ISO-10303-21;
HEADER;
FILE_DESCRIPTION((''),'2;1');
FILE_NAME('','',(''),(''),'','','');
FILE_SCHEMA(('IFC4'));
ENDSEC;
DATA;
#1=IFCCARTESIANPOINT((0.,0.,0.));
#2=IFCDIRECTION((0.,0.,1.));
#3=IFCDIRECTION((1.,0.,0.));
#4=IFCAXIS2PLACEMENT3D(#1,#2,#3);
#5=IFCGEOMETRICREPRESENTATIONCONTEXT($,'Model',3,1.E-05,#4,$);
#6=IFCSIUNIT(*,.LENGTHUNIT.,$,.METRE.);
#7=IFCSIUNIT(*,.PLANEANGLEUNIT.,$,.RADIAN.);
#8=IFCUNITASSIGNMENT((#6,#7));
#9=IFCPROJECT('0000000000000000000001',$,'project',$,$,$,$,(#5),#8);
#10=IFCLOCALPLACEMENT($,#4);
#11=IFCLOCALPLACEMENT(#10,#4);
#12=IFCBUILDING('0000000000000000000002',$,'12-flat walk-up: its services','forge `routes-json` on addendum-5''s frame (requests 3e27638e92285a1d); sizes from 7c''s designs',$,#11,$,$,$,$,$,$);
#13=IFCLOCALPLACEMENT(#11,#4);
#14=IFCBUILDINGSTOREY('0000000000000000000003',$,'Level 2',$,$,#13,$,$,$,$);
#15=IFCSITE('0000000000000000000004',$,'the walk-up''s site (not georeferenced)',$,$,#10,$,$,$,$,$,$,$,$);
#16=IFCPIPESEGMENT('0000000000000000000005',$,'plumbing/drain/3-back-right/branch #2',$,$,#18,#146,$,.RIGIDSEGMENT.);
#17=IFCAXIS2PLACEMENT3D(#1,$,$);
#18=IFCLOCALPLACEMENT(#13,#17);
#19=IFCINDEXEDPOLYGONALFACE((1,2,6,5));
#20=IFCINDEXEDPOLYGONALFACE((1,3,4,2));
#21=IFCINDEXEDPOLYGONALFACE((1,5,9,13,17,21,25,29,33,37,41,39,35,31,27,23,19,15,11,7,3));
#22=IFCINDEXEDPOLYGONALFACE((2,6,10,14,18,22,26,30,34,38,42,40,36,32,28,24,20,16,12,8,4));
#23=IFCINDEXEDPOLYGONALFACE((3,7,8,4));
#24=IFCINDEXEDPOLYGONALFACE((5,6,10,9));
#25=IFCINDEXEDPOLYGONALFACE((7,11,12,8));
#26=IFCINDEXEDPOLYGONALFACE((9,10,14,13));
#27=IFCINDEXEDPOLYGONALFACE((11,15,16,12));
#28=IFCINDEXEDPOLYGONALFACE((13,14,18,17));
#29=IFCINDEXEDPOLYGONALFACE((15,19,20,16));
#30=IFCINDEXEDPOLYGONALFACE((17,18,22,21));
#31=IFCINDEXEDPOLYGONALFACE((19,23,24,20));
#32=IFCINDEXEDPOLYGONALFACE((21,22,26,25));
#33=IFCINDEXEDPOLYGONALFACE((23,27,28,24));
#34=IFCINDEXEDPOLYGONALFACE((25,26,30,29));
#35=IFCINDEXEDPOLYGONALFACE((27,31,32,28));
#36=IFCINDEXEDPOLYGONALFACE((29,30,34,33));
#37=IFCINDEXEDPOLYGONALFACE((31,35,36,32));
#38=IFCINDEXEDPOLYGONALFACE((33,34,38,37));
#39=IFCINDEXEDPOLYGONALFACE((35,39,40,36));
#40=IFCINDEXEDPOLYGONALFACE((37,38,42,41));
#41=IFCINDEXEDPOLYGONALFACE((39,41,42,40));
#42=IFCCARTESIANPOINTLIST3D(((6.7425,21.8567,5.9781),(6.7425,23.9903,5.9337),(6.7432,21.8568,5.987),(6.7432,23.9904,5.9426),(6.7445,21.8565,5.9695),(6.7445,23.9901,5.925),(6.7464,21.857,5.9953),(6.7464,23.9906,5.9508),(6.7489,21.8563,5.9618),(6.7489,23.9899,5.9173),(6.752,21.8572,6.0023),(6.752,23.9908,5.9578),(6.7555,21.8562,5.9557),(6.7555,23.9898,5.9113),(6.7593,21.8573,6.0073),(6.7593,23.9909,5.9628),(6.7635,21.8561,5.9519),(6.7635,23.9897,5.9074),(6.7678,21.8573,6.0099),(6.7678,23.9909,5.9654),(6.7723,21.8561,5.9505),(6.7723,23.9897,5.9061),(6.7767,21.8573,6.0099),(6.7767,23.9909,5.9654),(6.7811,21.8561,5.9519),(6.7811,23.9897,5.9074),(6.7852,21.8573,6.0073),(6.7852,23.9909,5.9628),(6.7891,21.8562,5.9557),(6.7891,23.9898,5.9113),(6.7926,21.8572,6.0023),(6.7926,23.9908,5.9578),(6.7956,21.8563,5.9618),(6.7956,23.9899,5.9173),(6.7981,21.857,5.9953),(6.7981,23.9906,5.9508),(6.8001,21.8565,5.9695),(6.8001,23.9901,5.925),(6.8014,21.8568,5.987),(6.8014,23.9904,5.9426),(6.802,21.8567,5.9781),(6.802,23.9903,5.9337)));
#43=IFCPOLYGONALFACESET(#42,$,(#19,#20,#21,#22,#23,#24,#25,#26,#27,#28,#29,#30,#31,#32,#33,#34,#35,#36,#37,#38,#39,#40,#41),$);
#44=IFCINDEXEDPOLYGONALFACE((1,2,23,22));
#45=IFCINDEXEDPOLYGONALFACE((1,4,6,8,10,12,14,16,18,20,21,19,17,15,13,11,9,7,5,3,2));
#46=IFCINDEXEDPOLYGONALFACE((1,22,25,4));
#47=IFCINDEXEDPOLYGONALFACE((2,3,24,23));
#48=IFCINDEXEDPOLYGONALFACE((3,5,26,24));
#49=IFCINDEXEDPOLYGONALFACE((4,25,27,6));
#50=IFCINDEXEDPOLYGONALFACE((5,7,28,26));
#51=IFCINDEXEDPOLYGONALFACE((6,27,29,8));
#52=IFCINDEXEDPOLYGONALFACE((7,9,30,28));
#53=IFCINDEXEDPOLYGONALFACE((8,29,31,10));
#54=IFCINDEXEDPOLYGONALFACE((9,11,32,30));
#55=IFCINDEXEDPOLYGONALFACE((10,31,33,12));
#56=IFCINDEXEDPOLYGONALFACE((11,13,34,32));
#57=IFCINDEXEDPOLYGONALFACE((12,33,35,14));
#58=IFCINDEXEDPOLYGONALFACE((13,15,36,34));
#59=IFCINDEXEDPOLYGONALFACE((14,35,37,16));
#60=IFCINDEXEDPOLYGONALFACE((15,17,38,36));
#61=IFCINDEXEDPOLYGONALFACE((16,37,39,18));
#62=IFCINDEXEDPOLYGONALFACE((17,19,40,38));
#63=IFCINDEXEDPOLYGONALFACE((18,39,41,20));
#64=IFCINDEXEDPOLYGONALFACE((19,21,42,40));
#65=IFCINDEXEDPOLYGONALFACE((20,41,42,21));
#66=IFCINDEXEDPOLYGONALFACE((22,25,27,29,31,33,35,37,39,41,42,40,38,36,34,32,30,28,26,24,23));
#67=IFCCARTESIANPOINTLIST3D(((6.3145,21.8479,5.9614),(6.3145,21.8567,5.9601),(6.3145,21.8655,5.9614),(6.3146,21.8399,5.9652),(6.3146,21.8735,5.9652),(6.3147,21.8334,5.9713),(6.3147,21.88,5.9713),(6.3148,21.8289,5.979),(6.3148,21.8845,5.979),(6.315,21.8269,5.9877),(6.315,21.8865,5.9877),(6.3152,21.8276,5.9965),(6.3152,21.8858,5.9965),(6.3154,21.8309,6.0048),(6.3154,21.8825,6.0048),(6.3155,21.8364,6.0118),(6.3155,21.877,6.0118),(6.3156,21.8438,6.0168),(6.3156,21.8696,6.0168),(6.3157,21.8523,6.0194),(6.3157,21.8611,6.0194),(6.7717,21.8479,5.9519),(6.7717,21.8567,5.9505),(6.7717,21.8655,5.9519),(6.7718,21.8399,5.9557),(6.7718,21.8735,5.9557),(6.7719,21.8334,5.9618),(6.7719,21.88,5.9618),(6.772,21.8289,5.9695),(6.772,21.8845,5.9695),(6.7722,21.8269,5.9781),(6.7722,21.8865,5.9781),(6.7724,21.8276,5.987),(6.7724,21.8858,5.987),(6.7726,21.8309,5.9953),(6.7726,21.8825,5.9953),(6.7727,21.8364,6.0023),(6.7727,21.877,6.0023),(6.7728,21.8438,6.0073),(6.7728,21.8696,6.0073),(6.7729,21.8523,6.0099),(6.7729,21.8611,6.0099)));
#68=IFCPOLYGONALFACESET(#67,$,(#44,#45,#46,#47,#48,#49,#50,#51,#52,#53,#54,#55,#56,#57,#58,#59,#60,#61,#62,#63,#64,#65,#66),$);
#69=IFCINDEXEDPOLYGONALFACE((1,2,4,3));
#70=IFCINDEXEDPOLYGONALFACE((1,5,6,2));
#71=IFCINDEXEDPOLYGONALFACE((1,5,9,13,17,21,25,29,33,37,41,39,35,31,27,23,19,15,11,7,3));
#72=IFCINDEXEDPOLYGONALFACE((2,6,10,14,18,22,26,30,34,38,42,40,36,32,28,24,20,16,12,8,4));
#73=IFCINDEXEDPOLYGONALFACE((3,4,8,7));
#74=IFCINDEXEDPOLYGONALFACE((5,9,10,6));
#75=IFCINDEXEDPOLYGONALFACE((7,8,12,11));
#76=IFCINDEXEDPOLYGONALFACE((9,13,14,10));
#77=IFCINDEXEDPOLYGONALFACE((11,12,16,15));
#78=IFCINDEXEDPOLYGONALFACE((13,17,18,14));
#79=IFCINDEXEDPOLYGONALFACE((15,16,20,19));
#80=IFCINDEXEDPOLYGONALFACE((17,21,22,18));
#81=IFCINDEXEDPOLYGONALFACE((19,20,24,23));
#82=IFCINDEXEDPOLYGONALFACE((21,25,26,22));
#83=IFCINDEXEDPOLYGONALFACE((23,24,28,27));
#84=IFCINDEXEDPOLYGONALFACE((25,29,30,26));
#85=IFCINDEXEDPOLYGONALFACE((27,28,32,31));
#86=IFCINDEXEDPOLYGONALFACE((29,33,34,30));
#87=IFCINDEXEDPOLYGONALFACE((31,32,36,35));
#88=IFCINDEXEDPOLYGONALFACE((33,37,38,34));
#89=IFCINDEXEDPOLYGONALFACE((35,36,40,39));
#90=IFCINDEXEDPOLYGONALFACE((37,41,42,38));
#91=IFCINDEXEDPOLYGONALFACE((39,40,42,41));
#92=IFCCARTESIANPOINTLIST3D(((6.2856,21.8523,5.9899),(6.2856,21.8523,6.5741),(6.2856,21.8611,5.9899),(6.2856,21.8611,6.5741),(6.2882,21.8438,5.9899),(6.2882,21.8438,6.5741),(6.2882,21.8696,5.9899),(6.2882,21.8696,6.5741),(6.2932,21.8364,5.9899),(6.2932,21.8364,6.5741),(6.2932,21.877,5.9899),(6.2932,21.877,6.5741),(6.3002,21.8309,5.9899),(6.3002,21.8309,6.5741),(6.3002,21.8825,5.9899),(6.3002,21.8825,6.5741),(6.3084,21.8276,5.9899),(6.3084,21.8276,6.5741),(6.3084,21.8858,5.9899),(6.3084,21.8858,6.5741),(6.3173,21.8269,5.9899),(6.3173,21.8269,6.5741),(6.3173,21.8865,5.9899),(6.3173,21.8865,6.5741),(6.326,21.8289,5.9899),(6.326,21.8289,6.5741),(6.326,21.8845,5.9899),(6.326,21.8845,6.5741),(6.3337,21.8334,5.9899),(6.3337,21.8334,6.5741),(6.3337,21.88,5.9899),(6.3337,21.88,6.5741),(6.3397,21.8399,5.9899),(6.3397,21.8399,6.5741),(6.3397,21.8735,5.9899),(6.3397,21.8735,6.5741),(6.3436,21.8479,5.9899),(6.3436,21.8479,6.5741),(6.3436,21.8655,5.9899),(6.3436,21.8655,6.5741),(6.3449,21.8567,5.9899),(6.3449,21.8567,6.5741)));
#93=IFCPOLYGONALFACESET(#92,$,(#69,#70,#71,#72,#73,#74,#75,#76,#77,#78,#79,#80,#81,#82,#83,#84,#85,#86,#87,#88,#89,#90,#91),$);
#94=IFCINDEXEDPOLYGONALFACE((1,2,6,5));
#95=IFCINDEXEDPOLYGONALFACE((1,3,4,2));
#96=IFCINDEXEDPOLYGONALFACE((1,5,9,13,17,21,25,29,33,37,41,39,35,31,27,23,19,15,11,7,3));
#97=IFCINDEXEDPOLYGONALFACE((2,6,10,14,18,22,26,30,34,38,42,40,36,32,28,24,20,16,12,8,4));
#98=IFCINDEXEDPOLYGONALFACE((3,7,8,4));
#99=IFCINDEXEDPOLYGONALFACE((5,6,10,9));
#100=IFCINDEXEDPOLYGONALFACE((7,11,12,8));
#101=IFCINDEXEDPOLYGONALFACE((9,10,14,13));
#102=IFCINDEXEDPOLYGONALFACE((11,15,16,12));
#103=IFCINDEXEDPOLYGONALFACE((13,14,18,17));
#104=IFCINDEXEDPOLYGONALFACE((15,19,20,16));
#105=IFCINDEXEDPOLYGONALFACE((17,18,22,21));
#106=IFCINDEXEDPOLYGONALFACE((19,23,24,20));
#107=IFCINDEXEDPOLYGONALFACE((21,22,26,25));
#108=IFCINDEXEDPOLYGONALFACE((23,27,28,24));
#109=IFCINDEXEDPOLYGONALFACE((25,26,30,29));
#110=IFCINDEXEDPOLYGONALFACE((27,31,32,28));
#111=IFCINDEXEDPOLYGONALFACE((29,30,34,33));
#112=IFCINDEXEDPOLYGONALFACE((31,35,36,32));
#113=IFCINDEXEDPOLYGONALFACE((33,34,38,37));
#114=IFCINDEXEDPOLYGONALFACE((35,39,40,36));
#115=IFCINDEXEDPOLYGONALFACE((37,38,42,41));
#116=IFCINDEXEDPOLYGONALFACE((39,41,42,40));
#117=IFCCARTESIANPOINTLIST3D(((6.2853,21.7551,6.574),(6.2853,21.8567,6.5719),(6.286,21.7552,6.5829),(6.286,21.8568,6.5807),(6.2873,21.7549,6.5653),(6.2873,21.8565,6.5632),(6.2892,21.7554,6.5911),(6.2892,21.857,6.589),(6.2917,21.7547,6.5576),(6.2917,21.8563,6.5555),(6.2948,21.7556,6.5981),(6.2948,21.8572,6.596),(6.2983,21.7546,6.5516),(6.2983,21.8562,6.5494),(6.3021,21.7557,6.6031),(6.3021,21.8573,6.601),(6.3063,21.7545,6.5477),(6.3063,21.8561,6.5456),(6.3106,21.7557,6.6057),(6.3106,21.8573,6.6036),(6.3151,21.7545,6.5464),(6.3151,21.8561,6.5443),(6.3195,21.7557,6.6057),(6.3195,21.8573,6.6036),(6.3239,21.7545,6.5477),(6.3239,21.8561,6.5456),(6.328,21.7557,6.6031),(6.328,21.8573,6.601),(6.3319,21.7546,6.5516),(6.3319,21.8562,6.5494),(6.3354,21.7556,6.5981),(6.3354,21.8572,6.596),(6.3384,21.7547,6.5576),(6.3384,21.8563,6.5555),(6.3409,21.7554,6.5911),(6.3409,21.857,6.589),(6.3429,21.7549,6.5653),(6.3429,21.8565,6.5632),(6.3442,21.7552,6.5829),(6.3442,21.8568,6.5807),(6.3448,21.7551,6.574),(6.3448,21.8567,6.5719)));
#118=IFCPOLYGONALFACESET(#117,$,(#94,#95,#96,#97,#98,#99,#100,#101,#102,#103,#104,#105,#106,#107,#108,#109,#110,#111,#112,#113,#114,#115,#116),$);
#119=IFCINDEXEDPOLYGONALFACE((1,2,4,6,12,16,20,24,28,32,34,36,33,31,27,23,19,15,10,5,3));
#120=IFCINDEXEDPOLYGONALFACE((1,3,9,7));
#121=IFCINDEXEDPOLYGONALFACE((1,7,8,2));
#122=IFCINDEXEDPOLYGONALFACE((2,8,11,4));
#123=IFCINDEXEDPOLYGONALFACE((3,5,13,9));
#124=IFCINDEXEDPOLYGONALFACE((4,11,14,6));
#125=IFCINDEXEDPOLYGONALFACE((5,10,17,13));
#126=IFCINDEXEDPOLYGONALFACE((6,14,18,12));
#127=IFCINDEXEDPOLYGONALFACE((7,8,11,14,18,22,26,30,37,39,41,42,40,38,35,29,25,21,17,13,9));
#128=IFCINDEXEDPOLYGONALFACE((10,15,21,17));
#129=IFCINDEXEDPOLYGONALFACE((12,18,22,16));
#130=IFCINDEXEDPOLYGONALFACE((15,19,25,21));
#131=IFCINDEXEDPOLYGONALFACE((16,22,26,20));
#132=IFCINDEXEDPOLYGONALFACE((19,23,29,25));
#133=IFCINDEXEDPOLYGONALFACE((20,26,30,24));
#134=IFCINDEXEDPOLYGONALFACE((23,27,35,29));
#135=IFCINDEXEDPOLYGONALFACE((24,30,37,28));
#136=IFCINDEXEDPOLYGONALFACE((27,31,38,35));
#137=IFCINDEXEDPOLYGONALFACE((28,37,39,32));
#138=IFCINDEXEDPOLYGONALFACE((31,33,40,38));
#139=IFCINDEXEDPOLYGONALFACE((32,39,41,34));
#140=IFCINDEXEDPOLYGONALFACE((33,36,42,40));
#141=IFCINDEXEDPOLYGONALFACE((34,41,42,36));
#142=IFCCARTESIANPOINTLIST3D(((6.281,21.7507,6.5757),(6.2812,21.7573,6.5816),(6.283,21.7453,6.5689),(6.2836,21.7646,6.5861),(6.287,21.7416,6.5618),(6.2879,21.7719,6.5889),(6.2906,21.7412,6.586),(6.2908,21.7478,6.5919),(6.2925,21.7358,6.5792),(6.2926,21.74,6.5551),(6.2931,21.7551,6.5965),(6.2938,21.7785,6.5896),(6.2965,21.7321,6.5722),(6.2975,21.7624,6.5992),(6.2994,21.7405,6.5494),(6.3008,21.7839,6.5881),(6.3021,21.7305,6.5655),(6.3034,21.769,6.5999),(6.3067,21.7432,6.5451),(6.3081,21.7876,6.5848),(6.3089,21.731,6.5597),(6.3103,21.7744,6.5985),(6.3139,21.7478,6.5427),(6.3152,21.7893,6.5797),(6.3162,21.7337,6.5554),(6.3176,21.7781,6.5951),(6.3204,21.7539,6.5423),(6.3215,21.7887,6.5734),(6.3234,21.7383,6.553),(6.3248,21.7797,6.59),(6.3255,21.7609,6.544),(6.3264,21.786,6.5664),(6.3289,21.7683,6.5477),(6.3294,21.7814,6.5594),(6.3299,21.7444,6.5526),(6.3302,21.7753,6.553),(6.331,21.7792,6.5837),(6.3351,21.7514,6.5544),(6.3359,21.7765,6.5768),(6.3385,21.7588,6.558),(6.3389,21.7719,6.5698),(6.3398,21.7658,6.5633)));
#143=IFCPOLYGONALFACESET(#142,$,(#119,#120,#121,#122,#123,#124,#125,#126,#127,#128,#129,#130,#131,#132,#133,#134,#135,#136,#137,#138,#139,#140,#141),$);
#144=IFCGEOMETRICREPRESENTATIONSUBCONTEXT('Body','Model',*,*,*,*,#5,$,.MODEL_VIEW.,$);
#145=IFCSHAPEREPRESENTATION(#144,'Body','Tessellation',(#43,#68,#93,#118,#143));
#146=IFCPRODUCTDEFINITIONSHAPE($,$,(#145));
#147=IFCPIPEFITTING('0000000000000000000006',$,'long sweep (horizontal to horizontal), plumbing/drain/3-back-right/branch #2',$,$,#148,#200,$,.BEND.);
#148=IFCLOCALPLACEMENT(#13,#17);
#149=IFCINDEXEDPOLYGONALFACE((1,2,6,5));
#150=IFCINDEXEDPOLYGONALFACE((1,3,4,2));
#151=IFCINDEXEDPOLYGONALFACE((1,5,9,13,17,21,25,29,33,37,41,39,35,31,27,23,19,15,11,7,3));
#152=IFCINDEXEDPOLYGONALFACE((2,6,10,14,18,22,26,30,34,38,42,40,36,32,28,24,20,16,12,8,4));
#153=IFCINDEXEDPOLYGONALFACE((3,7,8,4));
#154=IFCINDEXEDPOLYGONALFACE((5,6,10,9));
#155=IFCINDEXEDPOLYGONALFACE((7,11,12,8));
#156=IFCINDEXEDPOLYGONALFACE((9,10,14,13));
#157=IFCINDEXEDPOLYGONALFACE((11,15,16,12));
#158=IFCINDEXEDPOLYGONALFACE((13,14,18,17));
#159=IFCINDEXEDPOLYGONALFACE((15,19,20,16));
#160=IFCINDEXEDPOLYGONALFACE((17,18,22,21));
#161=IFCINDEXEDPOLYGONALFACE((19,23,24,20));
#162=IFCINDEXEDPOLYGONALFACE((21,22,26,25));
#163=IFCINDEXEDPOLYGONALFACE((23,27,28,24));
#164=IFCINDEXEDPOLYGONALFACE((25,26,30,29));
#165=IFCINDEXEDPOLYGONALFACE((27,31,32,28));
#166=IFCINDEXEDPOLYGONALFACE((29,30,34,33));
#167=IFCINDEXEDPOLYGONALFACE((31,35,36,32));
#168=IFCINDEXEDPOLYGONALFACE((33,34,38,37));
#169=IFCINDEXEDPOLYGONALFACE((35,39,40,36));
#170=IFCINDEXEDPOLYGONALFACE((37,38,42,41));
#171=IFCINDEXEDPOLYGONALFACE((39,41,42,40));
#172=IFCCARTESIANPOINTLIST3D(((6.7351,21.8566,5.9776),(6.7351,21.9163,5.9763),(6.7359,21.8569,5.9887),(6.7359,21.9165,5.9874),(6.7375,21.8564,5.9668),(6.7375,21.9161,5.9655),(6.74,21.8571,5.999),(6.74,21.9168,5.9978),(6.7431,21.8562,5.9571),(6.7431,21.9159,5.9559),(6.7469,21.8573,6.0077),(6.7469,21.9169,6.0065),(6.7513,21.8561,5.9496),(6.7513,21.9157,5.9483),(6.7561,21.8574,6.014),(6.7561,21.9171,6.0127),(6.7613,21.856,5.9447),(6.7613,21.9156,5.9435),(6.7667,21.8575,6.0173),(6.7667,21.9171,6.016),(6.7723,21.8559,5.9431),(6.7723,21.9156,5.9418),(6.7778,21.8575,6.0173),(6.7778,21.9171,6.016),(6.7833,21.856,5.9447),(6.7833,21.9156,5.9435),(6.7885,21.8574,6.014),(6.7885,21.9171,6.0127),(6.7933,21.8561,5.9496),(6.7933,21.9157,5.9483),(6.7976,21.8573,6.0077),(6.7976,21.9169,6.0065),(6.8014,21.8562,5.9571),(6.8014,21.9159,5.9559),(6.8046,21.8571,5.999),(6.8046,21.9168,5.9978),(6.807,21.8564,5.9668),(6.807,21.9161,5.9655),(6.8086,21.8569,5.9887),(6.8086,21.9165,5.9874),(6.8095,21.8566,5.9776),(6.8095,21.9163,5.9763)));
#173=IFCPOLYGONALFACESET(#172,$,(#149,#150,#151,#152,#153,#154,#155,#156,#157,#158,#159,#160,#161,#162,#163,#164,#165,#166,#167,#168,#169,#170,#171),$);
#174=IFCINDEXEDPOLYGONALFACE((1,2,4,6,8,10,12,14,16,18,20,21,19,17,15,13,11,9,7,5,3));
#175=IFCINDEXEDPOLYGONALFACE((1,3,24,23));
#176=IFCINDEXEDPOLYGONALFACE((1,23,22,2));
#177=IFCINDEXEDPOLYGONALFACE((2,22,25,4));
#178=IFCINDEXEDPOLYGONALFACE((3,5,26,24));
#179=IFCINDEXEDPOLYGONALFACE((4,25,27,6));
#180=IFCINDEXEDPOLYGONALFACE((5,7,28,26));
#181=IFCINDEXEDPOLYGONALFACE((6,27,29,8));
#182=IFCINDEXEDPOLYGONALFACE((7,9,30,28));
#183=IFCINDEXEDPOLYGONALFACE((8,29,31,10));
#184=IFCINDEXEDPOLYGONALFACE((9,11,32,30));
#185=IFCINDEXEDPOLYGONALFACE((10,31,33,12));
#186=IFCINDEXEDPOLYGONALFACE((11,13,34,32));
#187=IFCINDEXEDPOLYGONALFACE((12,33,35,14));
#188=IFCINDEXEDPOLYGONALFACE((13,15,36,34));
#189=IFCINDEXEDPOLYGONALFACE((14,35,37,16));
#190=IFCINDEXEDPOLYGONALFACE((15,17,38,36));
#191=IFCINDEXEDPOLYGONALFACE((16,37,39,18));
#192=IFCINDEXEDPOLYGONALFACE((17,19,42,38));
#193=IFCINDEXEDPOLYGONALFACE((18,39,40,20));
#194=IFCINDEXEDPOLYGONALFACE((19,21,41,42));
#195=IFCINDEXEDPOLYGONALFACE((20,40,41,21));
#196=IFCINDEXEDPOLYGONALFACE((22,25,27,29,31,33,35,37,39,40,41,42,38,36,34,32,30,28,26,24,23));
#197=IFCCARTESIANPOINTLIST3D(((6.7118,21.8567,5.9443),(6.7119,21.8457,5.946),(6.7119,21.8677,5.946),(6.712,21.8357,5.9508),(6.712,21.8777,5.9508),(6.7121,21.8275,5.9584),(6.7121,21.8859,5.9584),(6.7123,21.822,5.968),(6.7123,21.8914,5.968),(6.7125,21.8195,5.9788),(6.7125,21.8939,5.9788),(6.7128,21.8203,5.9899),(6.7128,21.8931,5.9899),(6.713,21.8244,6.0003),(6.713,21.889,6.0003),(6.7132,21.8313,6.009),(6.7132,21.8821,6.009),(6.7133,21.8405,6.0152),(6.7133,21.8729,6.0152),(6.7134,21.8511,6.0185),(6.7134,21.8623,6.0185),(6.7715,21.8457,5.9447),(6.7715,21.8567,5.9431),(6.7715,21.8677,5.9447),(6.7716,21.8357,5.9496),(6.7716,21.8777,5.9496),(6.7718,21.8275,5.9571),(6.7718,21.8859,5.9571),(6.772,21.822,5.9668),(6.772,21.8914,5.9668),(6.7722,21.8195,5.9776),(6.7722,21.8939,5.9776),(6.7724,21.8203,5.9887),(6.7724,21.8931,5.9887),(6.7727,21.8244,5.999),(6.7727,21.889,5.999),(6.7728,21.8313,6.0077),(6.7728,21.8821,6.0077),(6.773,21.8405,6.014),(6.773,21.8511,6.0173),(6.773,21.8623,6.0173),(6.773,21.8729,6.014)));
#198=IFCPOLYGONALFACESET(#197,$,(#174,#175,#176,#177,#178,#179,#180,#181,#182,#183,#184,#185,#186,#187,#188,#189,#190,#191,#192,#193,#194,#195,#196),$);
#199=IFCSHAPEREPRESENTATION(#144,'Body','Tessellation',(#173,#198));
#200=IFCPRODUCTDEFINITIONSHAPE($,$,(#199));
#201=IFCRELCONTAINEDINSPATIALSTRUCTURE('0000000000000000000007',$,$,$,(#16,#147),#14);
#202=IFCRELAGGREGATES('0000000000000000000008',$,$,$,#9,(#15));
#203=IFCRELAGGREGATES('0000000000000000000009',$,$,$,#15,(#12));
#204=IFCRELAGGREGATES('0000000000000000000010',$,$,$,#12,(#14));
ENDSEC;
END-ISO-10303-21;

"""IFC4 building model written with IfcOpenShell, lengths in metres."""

from ifc_helpers import new_model, entity, si_unit, frame, origin_with_axes, place, context, subcontext, project, spatial, element, save


model = new_model("IFC4")

# Units and contexts
model_context = context("Model", 3, precision=1e-05, world=origin_with_axes())
body_context = subcontext(model_context, "Body", "Model", "MODEL_VIEW")
ifc_project = project(units=[si_unit("LENGTHUNIT", "METRE"), si_unit("PLANEANGLEUNIT", "RADIAN")], contexts=[model_context])

# Site, building, storey
site_placement = place(None, origin_with_axes())
site = spatial("IfcSite", under=ifc_project, at=site_placement, Name="the walk-up's site (not georeferenced)")
building_placement = place(site_placement, origin_with_axes())
building = spatial("IfcBuilding", under=site, at=building_placement, Name="12-flat walk-up: its services", Description="forge `routes-json` on addendum-5's frame (requests 3e27638e92285a1d); sizes from 7c's designs")
storey_placement = place(building_placement, origin_with_axes())
storey = spatial("IfcBuildingStorey", under=building, at=storey_placement, Name="Level 2")

# Pipe segment
pipe_segment_1_placement = place(storey_placement, frame((6.7723, 23.9903, 5.9359), z_axis=(0.0, 0.0, 1.0), x_axis=(1.0, 0.0, 0.0)))
element("IfcPipeSegment", 1, at=pipe_segment_1_placement, inside=storey, Name="plumbing/drain/3-back-right/branch #2", PredefinedType="RIGIDSEGMENT", context=body_context, shape_type="AdvancedSweptSolid", body=[
    entity("IfcSweptDiskSolid", entity("IfcPolyline", [entity("IfcCartesianPoint", [0.0, 0.0, 0.0]), entity("IfcCartesianPoint", [0.0, -2.1336, 0.0444])]), 0.0298),
    entity("IfcSweptDiskSolid", entity("IfcPolyline", [entity("IfcCartesianPoint", [0.0, -2.1336, 0.0444]), entity("IfcCartesianPoint", [-0.4572, -2.1336, 0.054])]), 0.0298),
    entity("IfcSweptDiskSolid", entity("IfcPolyline", [entity("IfcCartesianPoint", [-0.4572, -2.1336, 0.054]), entity("IfcCartesianPoint", [-0.4572, -2.1336, 0.6382])]), 0.0298),
    entity("IfcSweptDiskSolid", entity("IfcPolyline", [entity("IfcCartesianPoint", [-0.4572, -2.1336, 0.6382]), entity("IfcCartesianPoint", [-0.4572, -2.2352, 0.6403])]), 0.0298),
    entity("IfcSweptDiskSolid", entity("IfcPolyline", [entity("IfcCartesianPoint", [-0.4572, -2.2352, 0.6403]), entity("IfcCartesianPoint", [-0.4667, -2.2257, 0.63])]), 0.0298),
])

# Pipe fitting
pipe_fitting_1_placement = place(storey_placement, frame((6.7723, 21.9164, 5.9791), z_axis=(0.0, 0.0, 1.0), x_axis=(1.0, 0.0, 0.0)))
element("IfcPipeFitting", 2, at=pipe_fitting_1_placement, inside=storey, Name="long sweep (horizontal to horizontal), plumbing/drain/3-back-right/branch #2", PredefinedType="BEND", context=body_context, shape_type="AdvancedSweptSolid", body=[
    entity("IfcSweptDiskSolid", entity("IfcPolyline", [entity("IfcCartesianPoint", [0.0, 0.0, 0.0]), entity("IfcCartesianPoint", [0.0, -0.0597, 0.0012])]), 0.0373),
    entity("IfcSweptDiskSolid", entity("IfcPolyline", [entity("IfcCartesianPoint", [0.0, -0.0597, 0.0012]), entity("IfcCartesianPoint", [-0.0597, -0.0597, 0.0025])]), 0.0373),
])

save(model, "model.ifc")
